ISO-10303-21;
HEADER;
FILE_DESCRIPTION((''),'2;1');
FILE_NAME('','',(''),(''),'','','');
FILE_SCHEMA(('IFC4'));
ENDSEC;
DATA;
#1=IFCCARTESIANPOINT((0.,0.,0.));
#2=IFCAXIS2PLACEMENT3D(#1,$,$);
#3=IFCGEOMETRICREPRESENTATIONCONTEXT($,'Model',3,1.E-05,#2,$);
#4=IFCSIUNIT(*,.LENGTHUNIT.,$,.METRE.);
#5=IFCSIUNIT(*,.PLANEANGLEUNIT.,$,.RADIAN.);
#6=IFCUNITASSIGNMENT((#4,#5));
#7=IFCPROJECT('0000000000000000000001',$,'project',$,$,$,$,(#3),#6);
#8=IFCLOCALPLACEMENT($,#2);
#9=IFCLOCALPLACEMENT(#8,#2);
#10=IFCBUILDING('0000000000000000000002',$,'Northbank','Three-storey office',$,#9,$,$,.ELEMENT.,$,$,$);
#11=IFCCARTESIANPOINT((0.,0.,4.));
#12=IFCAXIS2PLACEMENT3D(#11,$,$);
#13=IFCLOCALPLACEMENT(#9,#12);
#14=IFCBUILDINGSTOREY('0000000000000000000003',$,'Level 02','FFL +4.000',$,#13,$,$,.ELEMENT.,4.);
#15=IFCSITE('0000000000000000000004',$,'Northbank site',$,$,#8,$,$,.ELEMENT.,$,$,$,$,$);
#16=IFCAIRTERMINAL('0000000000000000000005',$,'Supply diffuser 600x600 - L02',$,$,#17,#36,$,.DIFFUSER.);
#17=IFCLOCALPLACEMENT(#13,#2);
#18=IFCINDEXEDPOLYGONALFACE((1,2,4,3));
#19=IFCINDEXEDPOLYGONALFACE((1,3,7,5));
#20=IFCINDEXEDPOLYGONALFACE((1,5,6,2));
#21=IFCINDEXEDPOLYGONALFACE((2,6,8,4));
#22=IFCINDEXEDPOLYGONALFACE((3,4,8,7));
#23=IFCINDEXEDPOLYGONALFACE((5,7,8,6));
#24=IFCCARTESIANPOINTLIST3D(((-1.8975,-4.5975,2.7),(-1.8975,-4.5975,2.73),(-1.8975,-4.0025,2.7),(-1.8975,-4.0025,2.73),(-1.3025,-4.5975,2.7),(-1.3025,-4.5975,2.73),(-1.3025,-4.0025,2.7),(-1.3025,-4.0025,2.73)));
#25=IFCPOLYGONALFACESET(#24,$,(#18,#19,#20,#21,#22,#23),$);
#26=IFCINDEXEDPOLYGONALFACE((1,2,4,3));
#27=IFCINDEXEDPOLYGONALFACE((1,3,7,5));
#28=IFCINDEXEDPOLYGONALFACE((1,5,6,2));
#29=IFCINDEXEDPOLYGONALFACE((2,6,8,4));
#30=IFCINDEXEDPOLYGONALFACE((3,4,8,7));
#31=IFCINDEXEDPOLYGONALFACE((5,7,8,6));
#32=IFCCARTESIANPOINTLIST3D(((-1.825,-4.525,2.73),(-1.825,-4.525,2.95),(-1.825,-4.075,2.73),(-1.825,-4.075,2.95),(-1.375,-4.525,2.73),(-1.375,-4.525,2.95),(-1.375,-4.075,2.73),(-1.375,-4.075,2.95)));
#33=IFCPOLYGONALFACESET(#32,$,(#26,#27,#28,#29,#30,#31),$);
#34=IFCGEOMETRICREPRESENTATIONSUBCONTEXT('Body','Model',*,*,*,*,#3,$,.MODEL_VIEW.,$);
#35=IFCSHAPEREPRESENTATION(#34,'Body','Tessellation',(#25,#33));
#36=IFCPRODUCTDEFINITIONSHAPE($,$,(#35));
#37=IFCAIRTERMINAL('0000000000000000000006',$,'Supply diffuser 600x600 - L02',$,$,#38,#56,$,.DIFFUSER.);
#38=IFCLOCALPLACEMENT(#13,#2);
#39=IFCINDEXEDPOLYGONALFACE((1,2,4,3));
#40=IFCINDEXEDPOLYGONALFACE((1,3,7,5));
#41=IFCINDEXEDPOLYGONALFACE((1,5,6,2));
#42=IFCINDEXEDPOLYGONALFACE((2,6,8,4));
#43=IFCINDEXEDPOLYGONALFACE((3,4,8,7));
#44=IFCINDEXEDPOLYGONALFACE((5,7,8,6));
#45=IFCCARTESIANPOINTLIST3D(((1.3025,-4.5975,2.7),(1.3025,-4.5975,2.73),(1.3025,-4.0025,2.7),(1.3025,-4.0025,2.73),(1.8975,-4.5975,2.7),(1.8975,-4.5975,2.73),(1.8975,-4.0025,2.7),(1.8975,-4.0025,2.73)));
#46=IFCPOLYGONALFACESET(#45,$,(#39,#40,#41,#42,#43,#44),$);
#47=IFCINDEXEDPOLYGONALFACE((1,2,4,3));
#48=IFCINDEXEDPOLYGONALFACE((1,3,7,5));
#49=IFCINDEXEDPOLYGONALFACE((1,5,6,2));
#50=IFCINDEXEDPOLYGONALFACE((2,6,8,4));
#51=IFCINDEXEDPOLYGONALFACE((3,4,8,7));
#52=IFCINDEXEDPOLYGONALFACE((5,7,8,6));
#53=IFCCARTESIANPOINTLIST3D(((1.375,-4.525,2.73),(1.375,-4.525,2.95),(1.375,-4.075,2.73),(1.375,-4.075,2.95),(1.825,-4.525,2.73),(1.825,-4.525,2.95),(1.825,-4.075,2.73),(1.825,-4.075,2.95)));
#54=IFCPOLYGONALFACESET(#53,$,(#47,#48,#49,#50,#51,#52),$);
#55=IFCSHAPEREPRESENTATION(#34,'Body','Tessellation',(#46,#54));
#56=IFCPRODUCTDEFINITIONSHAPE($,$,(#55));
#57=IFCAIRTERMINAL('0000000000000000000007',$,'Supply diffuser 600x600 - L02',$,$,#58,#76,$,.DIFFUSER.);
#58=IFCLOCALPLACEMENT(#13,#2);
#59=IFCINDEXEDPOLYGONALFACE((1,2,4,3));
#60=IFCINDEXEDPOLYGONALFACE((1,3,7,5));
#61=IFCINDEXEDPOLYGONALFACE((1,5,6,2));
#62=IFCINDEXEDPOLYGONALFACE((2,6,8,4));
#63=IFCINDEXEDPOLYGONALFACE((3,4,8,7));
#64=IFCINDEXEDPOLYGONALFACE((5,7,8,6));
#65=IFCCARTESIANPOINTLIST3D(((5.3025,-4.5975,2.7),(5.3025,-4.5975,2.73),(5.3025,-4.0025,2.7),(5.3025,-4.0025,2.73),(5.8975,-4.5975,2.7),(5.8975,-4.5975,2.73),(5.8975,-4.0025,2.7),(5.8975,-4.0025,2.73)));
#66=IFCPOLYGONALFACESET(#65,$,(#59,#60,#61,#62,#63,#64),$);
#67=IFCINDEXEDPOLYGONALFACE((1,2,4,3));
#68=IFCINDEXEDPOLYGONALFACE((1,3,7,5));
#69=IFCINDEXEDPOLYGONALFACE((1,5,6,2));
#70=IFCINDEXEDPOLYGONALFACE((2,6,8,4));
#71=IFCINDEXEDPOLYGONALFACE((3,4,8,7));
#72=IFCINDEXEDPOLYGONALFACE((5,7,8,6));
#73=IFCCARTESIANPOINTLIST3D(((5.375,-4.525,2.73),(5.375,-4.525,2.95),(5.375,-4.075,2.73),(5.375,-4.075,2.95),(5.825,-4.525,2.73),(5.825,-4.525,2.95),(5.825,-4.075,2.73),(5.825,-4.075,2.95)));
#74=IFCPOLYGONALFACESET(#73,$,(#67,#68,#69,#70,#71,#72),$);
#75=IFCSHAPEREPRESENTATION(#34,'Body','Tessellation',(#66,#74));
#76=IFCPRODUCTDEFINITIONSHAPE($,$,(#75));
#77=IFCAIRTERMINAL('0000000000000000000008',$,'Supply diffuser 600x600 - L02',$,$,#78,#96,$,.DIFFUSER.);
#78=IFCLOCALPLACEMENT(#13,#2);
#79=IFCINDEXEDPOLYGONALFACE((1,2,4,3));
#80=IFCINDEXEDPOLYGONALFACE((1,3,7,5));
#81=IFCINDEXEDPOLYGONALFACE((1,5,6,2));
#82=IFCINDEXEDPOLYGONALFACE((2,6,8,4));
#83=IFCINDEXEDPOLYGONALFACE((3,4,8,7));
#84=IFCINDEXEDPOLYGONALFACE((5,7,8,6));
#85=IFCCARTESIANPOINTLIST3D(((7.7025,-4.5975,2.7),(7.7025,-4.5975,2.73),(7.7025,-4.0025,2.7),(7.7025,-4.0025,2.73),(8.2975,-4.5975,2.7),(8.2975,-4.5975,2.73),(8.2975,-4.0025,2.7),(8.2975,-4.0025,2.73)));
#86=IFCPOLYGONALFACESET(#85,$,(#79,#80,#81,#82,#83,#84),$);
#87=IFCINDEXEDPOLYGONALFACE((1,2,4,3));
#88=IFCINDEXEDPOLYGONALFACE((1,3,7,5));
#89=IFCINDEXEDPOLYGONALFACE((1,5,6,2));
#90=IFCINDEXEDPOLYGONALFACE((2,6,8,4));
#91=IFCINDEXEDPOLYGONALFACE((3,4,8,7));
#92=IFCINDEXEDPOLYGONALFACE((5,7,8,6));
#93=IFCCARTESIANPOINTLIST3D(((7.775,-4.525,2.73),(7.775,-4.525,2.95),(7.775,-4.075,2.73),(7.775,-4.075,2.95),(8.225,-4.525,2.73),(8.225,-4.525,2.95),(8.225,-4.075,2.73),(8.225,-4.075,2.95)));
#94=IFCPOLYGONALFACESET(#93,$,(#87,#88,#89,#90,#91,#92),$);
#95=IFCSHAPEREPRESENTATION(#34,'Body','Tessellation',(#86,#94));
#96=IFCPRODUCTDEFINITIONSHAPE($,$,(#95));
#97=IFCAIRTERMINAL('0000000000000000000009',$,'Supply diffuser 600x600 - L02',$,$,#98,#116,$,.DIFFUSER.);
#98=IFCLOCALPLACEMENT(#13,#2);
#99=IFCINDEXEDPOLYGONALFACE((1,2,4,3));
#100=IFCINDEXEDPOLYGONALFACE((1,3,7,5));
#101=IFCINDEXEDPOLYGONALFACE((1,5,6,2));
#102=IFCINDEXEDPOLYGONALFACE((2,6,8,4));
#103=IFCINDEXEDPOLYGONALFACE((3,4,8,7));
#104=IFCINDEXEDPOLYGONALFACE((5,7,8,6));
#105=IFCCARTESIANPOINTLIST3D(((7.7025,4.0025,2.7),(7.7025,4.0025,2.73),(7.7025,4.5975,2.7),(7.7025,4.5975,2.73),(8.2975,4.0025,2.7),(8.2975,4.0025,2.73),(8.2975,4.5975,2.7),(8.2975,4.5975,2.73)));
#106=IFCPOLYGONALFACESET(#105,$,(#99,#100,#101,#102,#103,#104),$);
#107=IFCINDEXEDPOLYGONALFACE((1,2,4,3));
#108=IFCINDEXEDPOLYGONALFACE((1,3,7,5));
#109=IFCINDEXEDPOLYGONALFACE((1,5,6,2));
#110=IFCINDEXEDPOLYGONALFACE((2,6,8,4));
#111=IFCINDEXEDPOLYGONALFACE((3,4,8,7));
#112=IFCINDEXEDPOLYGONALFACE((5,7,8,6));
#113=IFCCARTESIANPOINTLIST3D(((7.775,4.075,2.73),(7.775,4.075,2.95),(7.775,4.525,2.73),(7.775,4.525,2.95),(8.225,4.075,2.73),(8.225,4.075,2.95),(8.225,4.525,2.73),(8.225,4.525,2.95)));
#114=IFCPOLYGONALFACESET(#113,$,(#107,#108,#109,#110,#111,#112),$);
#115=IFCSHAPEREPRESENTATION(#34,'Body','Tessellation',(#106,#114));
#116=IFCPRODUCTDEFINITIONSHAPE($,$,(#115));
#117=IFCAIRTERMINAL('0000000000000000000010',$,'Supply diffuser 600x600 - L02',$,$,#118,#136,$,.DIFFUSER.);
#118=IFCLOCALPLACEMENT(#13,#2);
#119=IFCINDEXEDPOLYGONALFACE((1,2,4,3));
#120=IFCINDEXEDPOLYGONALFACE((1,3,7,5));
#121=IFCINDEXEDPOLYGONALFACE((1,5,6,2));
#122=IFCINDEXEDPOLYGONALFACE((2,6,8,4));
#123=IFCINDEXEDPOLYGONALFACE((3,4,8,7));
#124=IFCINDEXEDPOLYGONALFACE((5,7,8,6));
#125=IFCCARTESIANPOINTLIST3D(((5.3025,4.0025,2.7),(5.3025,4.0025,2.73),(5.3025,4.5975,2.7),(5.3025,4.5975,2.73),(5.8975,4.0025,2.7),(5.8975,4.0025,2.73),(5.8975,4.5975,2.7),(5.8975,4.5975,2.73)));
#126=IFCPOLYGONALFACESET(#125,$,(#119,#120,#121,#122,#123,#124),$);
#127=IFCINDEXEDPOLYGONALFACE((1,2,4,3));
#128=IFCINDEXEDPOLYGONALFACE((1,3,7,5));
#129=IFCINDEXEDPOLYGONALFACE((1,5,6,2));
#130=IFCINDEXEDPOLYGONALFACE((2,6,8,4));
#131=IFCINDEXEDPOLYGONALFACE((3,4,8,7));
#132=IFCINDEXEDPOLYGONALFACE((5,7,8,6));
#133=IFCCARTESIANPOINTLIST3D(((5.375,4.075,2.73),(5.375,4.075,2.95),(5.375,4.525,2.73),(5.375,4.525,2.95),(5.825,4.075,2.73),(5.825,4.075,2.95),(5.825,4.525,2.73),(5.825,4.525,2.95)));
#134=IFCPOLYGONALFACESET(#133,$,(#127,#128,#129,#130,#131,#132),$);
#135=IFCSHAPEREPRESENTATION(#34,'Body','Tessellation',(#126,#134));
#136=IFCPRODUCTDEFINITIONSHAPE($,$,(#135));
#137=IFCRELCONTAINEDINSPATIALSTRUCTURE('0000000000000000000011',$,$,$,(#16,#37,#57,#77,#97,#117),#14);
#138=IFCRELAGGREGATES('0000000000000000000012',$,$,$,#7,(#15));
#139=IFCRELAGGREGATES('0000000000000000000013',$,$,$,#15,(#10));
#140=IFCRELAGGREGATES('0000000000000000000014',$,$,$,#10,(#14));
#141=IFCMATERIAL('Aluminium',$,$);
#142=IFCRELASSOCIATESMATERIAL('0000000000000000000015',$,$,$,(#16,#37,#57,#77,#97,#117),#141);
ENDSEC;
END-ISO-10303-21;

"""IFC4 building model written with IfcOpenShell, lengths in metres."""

from ifc_helpers import new_model, si_unit, frame, origin, place, context, subcontext, project, spatial, rectangle, extrude, material, element, save


model = new_model("IFC4")

# Units and contexts
model_context = context("Model", 3, precision=1e-05, world=origin())
body_context = subcontext(model_context, "Body", "Model", "MODEL_VIEW")
ifc_project = project(units=[si_unit("LENGTHUNIT", "METRE"), si_unit("PLANEANGLEUNIT", "RADIAN")], contexts=[model_context])

# Site, building, storey
site_placement = place(None, origin())
site = spatial("IfcSite", under=ifc_project, at=site_placement, Name="Northbank site", CompositionType="ELEMENT")
building_placement = place(site_placement, origin())
building = spatial("IfcBuilding", under=site, at=building_placement, Name="Northbank", Description="Three-storey office", CompositionType="ELEMENT")
storey_placement = place(building_placement, frame((0.0, 0.0, 4.0)))
storey = spatial("IfcBuildingStorey", under=building, at=storey_placement, Name="Level 02", Description="FFL +4.000", CompositionType="ELEMENT", Elevation=4.0)

# Air terminal
ifc_material_1 = material(Name="Aluminium")
air_terminal_1_placement = place(storey_placement, frame((0.0, 0.0, -4.0)))
element("IfcAirTerminal", 1, at=air_terminal_1_placement, inside=storey, material=ifc_material_1, Name="Supply diffuser 600x600 - L02", PredefinedType="DIFFUSER", context=body_context, shape_type="SweptSolid", body=[
    extrude(rectangle(XDim=0.595, YDim=0.595), frame((-1.6, -4.3, 6.7)), (0.0, 0.0, 1.0), 0.03),
    extrude(rectangle(XDim=0.45, YDim=0.45), frame((-1.6, -4.3, 6.73)), (0.0, 0.0, 1.0), 0.22),
])

# Air terminal
air_terminal_2_placement = place(storey_placement, frame((0.0, 0.0, -4.0)))
element("IfcAirTerminal", 2, at=air_terminal_2_placement, inside=storey, material=ifc_material_1, Name="Supply diffuser 600x600 - L02", PredefinedType="DIFFUSER", context=body_context, shape_type="SweptSolid", body=[
    extrude(rectangle(XDim=0.595, YDim=0.595), frame((1.6, -4.3, 6.7)), (0.0, 0.0, 1.0), 0.03),
    extrude(rectangle(XDim=0.45, YDim=0.45), frame((1.6, -4.3, 6.73)), (0.0, 0.0, 1.0), 0.22),
])

# Air terminal
air_terminal_3_placement = place(storey_placement, frame((0.0, 0.0, -4.0)))
element("IfcAirTerminal", 3, at=air_terminal_3_placement, inside=storey, material=ifc_material_1, Name="Supply diffuser 600x600 - L02", PredefinedType="DIFFUSER", context=body_context, shape_type="SweptSolid", body=[
    extrude(rectangle(XDim=0.595, YDim=0.595), frame((5.6, -4.3, 6.7)), (0.0, 0.0, 1.0), 0.03),
    extrude(rectangle(XDim=0.45, YDim=0.45), frame((5.6, -4.3, 6.73)), (0.0, 0.0, 1.0), 0.22),
])

# Air terminal
air_terminal_4_placement = place(storey_placement, frame((0.0, 0.0, -4.0)))
element("IfcAirTerminal", 4, at=air_terminal_4_placement, inside=storey, material=ifc_material_1, Name="Supply diffuser 600x600 - L02", PredefinedType="DIFFUSER", context=body_context, shape_type="SweptSolid", body=[
    extrude(rectangle(XDim=0.595, YDim=0.595), frame((8.0, -4.3, 6.7)), (0.0, 0.0, 1.0), 0.03),
    extrude(rectangle(XDim=0.45, YDim=0.45), frame((8.0, -4.3, 6.73)), (0.0, 0.0, 1.0), 0.22),
])

# Air terminal
air_terminal_5_placement = place(storey_placement, frame((0.0, 0.0, -4.0)))
element("IfcAirTerminal", 5, at=air_terminal_5_placement, inside=storey, material=ifc_material_1, Name="Supply diffuser 600x600 - L02", PredefinedType="DIFFUSER", context=body_context, shape_type="SweptSolid", body=[
    extrude(rectangle(XDim=0.595, YDim=0.595), frame((8.0, 4.3, 6.7)), (0.0, 0.0, 1.0), 0.03),
    extrude(rectangle(XDim=0.45, YDim=0.45), frame((8.0, 4.3, 6.73)), (0.0, 0.0, 1.0), 0.22),
])

# Air terminal
air_terminal_6_placement = place(storey_placement, frame((0.0, 0.0, -4.0)))
element("IfcAirTerminal", 6, at=air_terminal_6_placement, inside=storey, material=ifc_material_1, Name="Supply diffuser 600x600 - L02", PredefinedType="DIFFUSER", context=body_context, shape_type="SweptSolid", body=[
    extrude(rectangle(XDim=0.595, YDim=0.595), frame((5.6, 4.3, 6.7)), (0.0, 0.0, 1.0), 0.03),
    extrude(rectangle(XDim=0.45, YDim=0.45), frame((5.6, 4.3, 6.73)), (0.0, 0.0, 1.0), 0.22),
])

save(model, "model.ifc")
